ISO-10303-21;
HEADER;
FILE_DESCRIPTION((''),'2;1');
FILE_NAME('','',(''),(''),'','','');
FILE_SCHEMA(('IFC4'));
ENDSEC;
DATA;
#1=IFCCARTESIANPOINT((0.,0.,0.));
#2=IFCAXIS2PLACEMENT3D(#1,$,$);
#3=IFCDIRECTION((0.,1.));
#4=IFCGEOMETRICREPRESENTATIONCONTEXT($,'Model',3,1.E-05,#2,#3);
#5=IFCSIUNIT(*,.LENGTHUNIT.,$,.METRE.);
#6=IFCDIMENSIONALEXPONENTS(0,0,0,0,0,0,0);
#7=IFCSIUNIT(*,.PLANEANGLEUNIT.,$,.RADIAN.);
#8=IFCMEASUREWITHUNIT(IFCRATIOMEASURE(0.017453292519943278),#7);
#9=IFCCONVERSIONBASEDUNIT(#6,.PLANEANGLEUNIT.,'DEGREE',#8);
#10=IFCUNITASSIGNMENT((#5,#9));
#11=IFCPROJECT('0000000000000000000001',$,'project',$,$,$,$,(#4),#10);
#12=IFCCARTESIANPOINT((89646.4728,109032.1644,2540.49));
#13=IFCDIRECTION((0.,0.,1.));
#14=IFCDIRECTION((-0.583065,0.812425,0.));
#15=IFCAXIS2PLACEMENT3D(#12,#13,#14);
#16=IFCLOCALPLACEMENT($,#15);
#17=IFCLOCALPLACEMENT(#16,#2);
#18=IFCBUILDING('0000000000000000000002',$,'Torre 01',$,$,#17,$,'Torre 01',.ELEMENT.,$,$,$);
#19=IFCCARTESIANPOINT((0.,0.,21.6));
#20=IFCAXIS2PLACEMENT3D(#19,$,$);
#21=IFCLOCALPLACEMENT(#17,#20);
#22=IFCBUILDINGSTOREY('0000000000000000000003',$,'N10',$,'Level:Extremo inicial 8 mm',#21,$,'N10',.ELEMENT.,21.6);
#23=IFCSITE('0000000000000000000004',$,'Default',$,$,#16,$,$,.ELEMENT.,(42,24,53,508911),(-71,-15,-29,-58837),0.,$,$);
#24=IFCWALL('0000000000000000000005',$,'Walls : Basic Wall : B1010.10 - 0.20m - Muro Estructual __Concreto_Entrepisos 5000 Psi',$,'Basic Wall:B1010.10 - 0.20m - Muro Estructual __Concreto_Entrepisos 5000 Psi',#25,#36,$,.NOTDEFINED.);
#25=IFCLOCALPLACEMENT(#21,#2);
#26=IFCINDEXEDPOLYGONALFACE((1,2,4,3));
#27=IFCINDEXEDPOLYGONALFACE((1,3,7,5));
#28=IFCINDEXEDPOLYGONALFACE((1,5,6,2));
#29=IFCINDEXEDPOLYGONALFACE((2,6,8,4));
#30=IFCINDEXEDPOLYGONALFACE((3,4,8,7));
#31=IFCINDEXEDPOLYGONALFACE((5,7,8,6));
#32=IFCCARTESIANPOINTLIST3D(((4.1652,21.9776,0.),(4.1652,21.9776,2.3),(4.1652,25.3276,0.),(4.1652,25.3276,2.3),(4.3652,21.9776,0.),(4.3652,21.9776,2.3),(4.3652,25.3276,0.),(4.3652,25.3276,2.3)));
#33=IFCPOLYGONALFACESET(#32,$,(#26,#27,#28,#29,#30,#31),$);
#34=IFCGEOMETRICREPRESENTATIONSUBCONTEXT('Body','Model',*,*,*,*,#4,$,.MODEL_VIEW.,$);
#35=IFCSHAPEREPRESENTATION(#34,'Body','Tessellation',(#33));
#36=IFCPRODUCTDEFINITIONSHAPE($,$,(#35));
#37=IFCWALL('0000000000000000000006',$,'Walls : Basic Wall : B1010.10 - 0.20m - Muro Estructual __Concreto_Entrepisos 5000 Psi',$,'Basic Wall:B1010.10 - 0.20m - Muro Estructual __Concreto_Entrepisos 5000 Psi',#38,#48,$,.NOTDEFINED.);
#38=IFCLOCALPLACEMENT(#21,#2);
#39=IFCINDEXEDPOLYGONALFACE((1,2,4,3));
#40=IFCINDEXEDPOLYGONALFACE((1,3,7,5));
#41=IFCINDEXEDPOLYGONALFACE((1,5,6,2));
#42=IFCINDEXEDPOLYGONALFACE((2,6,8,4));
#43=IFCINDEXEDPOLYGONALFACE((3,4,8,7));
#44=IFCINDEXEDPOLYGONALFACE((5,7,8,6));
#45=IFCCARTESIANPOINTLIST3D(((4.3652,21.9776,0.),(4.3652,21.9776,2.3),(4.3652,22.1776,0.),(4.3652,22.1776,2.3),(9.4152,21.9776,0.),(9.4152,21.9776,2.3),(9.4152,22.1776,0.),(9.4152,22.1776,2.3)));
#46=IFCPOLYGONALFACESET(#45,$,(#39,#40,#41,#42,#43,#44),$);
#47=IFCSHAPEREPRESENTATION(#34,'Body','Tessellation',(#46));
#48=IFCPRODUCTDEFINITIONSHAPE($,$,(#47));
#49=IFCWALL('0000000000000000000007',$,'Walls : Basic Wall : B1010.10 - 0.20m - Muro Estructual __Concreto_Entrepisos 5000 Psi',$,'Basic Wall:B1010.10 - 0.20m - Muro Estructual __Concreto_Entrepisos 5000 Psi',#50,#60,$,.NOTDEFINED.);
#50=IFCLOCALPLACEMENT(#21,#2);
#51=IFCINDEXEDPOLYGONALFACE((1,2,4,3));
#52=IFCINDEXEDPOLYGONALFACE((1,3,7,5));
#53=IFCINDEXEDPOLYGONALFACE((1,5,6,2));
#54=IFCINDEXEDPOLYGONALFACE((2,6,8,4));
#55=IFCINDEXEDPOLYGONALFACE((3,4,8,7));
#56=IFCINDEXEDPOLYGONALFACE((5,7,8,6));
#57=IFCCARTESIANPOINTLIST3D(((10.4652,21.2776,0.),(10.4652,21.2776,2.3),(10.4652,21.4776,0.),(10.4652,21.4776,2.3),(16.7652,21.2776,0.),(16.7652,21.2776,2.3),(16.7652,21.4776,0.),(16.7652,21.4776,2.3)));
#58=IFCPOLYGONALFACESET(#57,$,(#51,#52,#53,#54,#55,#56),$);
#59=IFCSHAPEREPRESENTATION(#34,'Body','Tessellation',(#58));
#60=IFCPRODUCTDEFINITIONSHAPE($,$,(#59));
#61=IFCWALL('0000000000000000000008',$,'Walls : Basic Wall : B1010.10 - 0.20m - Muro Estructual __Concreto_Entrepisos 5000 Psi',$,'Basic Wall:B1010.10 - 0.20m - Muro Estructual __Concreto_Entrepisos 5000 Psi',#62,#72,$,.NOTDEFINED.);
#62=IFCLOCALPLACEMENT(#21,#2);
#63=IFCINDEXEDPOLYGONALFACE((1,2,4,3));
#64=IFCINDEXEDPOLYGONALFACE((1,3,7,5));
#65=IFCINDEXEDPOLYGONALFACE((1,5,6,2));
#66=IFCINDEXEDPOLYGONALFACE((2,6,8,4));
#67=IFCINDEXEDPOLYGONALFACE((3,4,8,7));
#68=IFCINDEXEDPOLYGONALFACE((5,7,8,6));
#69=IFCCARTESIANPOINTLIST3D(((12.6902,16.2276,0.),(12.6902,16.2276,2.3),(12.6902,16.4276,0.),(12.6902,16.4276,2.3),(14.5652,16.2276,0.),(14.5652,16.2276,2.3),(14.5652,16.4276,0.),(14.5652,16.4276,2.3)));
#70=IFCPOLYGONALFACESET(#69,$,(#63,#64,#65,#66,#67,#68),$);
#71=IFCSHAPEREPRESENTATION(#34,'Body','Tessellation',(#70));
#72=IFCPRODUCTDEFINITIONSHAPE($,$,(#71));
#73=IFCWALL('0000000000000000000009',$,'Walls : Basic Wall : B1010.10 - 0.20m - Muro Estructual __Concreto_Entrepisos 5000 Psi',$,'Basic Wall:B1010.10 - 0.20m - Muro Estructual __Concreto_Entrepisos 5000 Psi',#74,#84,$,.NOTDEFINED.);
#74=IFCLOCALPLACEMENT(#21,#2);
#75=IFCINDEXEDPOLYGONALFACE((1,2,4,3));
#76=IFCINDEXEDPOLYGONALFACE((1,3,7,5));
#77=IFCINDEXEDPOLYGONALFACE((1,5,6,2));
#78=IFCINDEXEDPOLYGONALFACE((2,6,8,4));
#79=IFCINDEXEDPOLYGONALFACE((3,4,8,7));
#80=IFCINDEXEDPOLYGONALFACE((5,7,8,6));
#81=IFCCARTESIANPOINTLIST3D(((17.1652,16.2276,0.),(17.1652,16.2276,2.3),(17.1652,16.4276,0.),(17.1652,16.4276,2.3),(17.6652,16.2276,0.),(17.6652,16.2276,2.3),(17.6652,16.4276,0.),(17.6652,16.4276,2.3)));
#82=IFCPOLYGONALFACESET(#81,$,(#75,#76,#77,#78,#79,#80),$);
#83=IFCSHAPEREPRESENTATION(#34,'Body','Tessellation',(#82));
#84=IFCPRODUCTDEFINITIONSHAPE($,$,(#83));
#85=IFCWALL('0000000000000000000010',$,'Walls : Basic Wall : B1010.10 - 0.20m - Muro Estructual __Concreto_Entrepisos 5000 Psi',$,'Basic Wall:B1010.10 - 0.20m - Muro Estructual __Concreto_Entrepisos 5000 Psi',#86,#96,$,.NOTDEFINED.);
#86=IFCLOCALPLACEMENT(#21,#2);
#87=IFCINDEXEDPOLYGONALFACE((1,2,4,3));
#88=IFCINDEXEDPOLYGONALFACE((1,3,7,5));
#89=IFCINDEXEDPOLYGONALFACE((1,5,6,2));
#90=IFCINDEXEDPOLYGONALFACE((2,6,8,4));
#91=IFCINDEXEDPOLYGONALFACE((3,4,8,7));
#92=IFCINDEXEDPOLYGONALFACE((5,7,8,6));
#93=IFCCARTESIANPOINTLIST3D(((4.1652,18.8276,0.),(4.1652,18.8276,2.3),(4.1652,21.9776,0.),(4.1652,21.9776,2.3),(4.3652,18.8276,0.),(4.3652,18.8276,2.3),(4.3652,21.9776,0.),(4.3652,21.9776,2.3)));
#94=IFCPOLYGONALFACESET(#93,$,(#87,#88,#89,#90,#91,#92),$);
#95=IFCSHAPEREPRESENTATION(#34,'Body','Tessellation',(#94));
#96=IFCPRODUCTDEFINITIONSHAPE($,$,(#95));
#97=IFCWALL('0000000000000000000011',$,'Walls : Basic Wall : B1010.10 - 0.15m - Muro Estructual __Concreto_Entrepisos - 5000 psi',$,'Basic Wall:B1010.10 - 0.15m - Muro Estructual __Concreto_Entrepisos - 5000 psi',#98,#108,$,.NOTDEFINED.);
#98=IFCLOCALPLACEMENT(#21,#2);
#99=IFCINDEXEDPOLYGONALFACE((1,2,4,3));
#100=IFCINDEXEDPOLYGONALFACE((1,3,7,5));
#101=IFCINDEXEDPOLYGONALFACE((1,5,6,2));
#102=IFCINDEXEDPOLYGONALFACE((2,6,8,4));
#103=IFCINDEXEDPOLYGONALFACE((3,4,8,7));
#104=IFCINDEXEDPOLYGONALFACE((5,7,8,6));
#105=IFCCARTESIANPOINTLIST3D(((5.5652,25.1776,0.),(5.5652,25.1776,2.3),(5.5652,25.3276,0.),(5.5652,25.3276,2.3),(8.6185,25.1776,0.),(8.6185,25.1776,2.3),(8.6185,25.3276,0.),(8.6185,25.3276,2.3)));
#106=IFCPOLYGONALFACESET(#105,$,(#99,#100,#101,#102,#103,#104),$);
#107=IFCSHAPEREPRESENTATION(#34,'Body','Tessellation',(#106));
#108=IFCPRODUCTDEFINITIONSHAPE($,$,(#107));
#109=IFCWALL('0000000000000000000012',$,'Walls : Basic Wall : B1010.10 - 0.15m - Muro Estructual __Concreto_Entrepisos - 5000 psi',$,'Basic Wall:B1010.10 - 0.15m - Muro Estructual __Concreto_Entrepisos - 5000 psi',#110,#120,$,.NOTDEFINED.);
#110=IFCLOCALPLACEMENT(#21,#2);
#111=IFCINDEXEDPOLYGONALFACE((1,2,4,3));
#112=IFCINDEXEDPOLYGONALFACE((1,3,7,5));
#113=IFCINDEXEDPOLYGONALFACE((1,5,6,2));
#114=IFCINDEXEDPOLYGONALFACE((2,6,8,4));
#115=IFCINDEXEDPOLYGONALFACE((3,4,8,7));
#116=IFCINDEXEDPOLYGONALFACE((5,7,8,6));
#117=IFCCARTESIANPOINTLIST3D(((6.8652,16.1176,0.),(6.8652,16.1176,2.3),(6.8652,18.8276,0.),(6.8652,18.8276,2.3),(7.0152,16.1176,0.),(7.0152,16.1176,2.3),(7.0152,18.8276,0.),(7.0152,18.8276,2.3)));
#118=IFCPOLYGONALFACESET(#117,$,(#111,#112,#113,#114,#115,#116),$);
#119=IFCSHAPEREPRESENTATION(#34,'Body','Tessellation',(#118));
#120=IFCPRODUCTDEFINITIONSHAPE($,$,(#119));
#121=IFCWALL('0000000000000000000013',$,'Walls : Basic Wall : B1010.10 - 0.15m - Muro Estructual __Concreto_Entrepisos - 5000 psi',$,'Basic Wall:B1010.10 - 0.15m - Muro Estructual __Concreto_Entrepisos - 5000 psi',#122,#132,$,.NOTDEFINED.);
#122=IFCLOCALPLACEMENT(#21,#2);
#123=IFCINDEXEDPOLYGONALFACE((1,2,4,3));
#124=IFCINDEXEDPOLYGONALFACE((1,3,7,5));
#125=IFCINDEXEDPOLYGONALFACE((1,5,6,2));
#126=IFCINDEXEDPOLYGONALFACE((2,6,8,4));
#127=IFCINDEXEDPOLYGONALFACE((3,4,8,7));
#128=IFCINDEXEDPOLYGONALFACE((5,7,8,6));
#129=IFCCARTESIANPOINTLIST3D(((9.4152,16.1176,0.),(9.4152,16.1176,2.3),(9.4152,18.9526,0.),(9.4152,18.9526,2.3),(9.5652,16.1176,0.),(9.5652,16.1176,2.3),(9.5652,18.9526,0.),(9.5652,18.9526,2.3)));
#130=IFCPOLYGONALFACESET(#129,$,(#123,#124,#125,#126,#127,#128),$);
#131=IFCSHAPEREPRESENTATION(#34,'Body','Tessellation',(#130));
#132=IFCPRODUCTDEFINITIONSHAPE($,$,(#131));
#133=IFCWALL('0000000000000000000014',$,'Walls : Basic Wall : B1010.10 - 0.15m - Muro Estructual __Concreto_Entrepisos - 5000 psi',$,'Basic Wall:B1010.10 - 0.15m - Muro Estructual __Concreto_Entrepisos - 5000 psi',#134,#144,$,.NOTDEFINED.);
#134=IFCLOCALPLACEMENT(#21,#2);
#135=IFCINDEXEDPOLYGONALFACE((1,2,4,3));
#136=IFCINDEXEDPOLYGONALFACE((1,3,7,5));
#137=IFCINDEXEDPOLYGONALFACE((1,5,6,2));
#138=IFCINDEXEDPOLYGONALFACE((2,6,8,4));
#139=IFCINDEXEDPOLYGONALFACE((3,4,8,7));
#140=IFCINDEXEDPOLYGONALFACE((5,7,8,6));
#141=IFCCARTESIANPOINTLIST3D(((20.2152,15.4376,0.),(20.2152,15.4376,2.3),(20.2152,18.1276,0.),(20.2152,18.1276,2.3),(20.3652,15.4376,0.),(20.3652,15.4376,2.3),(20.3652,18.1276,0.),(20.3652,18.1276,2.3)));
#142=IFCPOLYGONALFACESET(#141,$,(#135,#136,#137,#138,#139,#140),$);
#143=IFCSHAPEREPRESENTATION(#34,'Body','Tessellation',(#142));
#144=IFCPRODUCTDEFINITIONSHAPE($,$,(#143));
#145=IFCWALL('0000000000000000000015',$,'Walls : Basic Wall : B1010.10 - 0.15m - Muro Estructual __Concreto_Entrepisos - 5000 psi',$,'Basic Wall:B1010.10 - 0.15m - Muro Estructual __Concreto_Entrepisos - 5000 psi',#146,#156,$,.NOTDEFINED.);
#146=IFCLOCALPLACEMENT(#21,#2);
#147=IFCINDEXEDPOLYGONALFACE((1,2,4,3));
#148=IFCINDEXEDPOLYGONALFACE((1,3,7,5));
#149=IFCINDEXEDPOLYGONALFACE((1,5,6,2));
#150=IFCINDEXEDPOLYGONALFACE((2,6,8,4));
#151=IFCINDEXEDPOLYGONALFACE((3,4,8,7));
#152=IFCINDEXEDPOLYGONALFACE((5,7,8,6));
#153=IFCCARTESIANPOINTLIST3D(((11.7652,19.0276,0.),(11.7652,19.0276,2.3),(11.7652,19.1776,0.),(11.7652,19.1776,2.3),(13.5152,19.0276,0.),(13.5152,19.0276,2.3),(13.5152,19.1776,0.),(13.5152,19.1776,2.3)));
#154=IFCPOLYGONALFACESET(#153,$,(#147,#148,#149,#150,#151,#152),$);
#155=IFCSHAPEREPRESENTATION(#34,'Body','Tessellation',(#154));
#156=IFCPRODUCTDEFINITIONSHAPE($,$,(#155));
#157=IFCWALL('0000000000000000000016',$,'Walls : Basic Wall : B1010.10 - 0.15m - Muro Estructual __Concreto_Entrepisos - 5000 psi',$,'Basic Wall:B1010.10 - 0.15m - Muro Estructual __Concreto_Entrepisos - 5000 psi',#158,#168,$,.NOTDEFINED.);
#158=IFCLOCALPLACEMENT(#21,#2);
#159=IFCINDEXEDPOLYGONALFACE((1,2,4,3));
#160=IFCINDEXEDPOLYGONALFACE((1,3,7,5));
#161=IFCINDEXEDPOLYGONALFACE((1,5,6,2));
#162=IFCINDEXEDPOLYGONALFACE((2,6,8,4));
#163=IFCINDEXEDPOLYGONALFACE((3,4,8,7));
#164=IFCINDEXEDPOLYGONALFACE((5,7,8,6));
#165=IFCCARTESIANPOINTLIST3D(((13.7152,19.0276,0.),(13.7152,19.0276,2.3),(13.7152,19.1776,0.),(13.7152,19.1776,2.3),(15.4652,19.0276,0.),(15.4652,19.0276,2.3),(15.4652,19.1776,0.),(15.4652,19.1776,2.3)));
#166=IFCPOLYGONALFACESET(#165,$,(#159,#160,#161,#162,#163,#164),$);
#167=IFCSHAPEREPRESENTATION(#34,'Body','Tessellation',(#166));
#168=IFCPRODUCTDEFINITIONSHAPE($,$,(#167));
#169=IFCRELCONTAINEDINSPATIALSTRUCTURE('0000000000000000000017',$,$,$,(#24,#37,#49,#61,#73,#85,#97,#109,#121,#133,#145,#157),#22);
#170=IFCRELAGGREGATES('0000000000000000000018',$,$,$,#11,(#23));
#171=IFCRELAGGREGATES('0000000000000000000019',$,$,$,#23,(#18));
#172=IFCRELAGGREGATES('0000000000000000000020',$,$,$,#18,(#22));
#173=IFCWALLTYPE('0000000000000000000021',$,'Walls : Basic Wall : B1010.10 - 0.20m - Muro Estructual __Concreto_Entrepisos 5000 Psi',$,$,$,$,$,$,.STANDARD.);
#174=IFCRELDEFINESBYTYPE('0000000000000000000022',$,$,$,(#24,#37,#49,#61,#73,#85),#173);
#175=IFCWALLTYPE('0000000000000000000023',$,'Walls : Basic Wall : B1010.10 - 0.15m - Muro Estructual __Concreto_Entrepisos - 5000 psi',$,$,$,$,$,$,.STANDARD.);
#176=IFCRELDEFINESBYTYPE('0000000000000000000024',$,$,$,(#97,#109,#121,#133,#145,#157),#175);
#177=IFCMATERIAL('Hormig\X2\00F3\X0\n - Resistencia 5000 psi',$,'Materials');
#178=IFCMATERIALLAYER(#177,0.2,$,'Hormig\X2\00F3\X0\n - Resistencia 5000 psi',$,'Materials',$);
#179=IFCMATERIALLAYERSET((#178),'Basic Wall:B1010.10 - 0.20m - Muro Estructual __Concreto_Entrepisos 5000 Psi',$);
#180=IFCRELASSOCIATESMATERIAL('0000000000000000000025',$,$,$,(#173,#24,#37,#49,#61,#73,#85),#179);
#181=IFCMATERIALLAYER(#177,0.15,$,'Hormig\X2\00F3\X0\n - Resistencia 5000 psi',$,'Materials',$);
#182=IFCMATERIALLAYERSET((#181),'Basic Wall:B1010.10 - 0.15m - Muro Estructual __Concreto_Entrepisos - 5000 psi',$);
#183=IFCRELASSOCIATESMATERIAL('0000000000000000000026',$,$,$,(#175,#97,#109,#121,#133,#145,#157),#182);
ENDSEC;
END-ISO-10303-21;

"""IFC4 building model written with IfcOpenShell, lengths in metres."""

from ifc_helpers import new_model, entity, si_unit, converted_unit, direction, frame, frame_2d, origin, place, context, subcontext, project, spatial, rectangle, extrude, material, layer, layer_set, layer_usage, type_object, element, save


model = new_model("IFC4")

# Units and contexts
model_context = context("Model", 3, precision=1e-05, world=origin(), true_north=direction((0.0, 1.0)))
body_context = subcontext(model_context, "Body", "Model", "MODEL_VIEW")
ifc_project = project(units=[si_unit("LENGTHUNIT", "METRE"), converted_unit("PLANEANGLEUNIT", "DEGREE", entity("IfcRatioMeasure", 0.017453292519943278), si_unit("PLANEANGLEUNIT", "RADIAN"), dimensions=[0, 0, 0, 0, 0, 0, 0])], contexts=[model_context])

# Site, building, storey
site_placement = place(None, frame((89646.4728, 109032.1644, 2540.49), z_axis=(0.0, 0.0, 1.0), x_axis=(-0.583065, 0.812425, 0.0)))
site = spatial("IfcSite", under=ifc_project, at=site_placement, Name="Default", CompositionType="ELEMENT", RefLatitude=(42, 24, 53, 508911), RefLongitude=(-71, -15, -29, -58837), RefElevation=0.0)
building_placement = place(site_placement, origin())
building = spatial("IfcBuilding", under=site, at=building_placement, Name="Torre 01", LongName="Torre 01", CompositionType="ELEMENT")
storey_placement = place(building_placement, frame((0.0, 0.0, 21.6)))
storey = spatial("IfcBuildingStorey", under=building, at=storey_placement, Name="N10", ObjectType="Level:Extremo inicial 8 mm", LongName="N10", CompositionType="ELEMENT", Elevation=21.6)

# Walls
ifc_material = material(Name="Hormigón - Resistencia 5000 psi", Category="Materials")
ifc_layer_1 = layer(ifc_material, 0.2, Name="Hormigón - Resistencia 5000 psi", Category="Materials")
ifc_layer_set_1 = layer_set([ifc_layer_1], Name="Basic Wall:B1010.10 - 0.20m - Muro Estructual __Concreto_Entrepisos 5000 Psi")
ifc_layer_usage_1 = layer_usage(ifc_layer_set_1, "AXIS2", "NEGATIVE", 0.1)
wall_type_1 = type_object("IfcWallType", Name="Walls : Basic Wall : B1010.10 - 0.20m - Muro Estructual __Concreto_Entrepisos 5000 Psi", PredefinedType="STANDARD", material=ifc_layer_set_1)
wall_1_placement = place(storey_placement, frame((4.2652, 25.3276, 0.0), z_axis=(0.0, 0.0, 1.0), x_axis=(0.0, -1.0, 0.0)))
element("IfcWall", 1, at=wall_1_placement, inside=storey, type_object=wall_type_1, material=ifc_layer_usage_1, Name="Walls : Basic Wall : B1010.10 - 0.20m - Muro Estructual __Concreto_Entrepisos 5000 Psi", ObjectType="Basic Wall:B1010.10 - 0.20m - Muro Estructual __Concreto_Entrepisos 5000 Psi", PredefinedType="NOTDEFINED", context=body_context, shape_type="SweptSolid", body=[
    extrude(rectangle(XDim=3.35, YDim=0.2, at=frame_2d((1.675, 0.0), x_axis=(-1.0, 0.0))), origin(), (0.0, 0.0, 1.0), 2.3),
])
ifc_layer_usage_2 = layer_usage(ifc_layer_set_1, "AXIS2", "NEGATIVE", 0.1)
wall_2_placement = place(storey_placement, frame((4.3652, 22.0776, 0.0)))
element("IfcWall", 2, at=wall_2_placement, inside=storey, type_object=wall_type_1, material=ifc_layer_usage_2, Name="Walls : Basic Wall : B1010.10 - 0.20m - Muro Estructual __Concreto_Entrepisos 5000 Psi", ObjectType="Basic Wall:B1010.10 - 0.20m - Muro Estructual __Concreto_Entrepisos 5000 Psi", PredefinedType="NOTDEFINED", context=body_context, shape_type="SweptSolid", body=[
    extrude(rectangle(XDim=5.05, YDim=0.2, at=frame_2d((2.525, 0.0), x_axis=(-1.0, 0.0))), origin(), (0.0, 0.0, 1.0), 2.3),
])
ifc_layer_usage_3 = layer_usage(ifc_layer_set_1, "AXIS2", "NEGATIVE", 0.1)
wall_3_placement = place(storey_placement, frame((10.4652, 21.3776, 0.0)))
element("IfcWall", 3, at=wall_3_placement, inside=storey, type_object=wall_type_1, material=ifc_layer_usage_3, Name="Walls : Basic Wall : B1010.10 - 0.20m - Muro Estructual __Concreto_Entrepisos 5000 Psi", ObjectType="Basic Wall:B1010.10 - 0.20m - Muro Estructual __Concreto_Entrepisos 5000 Psi", PredefinedType="NOTDEFINED", context=body_context, shape_type="SweptSolid", body=[
    extrude(rectangle(XDim=6.3, YDim=0.2, at=frame_2d((3.15, 0.0), x_axis=(-1.0, 0.0))), origin(), (0.0, 0.0, 1.0), 2.3),
])
ifc_layer_usage_4 = layer_usage(ifc_layer_set_1, "AXIS2", "NEGATIVE", 0.1)
wall_4_placement = place(storey_placement, frame((12.6902, 16.3276, 0.0)))
element("IfcWall", 4, at=wall_4_placement, inside=storey, type_object=wall_type_1, material=ifc_layer_usage_4, Name="Walls : Basic Wall : B1010.10 - 0.20m - Muro Estructual __Concreto_Entrepisos 5000 Psi", ObjectType="Basic Wall:B1010.10 - 0.20m - Muro Estructual __Concreto_Entrepisos 5000 Psi", PredefinedType="NOTDEFINED", context=body_context, shape_type="SweptSolid", body=[
    extrude(rectangle(XDim=1.875, YDim=0.2, at=frame_2d((0.9375, 0.0), x_axis=(-1.0, 0.0))), origin(), (0.0, 0.0, 1.0), 2.3),
])
ifc_layer_usage_5 = layer_usage(ifc_layer_set_1, "AXIS2", "NEGATIVE", 0.1)
wall_5_placement = place(storey_placement, frame((17.6652, 16.3276, 0.0), z_axis=(0.0, 0.0, 1.0), x_axis=(-1.0, 0.0, 0.0)))
element("IfcWall", 5, at=wall_5_placement, inside=storey, type_object=wall_type_1, material=ifc_layer_usage_5, Name="Walls : Basic Wall : B1010.10 - 0.20m - Muro Estructual __Concreto_Entrepisos 5000 Psi", ObjectType="Basic Wall:B1010.10 - 0.20m - Muro Estructual __Concreto_Entrepisos 5000 Psi", PredefinedType="NOTDEFINED", context=body_context, shape_type="SweptSolid", body=[
    extrude(rectangle(XDim=0.5, YDim=0.2, at=frame_2d((0.25, 0.0), x_axis=(-1.0, 0.0))), origin(), (0.0, 0.0, 1.0), 2.3),
])
ifc_layer_usage_6 = layer_usage(ifc_layer_set_1, "AXIS2", "NEGATIVE", 0.1)
wall_6_placement = place(storey_placement, frame((4.2652, 21.9776, 0.0), z_axis=(0.0, 0.0, 1.0), x_axis=(0.0, -1.0, 0.0)))
element("IfcWall", 6, at=wall_6_placement, inside=storey, type_object=wall_type_1, material=ifc_layer_usage_6, Name="Walls : Basic Wall : B1010.10 - 0.20m - Muro Estructual __Concreto_Entrepisos 5000 Psi", ObjectType="Basic Wall:B1010.10 - 0.20m - Muro Estructual __Concreto_Entrepisos 5000 Psi", PredefinedType="NOTDEFINED", context=body_context, shape_type="SweptSolid", body=[
    extrude(rectangle(XDim=3.15, YDim=0.2, at=frame_2d((1.575, 0.0), x_axis=(-1.0, 0.0))), origin(), (0.0, 0.0, 1.0), 2.3),
])
ifc_layer_2 = layer(ifc_material, 0.15, Name="Hormigón - Resistencia 5000 psi", Category="Materials")
ifc_layer_set_2 = layer_set([ifc_layer_2], Name="Basic Wall:B1010.10 - 0.15m - Muro Estructual __Concreto_Entrepisos - 5000 psi")
ifc_layer_usage_7 = layer_usage(ifc_layer_set_2, "AXIS2", "NEGATIVE", 0.075)
wall_type_2 = type_object("IfcWallType", Name="Walls : Basic Wall : B1010.10 - 0.15m - Muro Estructual __Concreto_Entrepisos - 5000 psi", PredefinedType="STANDARD", material=ifc_layer_set_2)
wall_7_placement = place(storey_placement, frame((5.5652, 25.2526, 0.0)))
element("IfcWall", 7, at=wall_7_placement, inside=storey, type_object=wall_type_2, material=ifc_layer_usage_7, Name="Walls : Basic Wall : B1010.10 - 0.15m - Muro Estructual __Concreto_Entrepisos - 5000 psi", ObjectType="Basic Wall:B1010.10 - 0.15m - Muro Estructual __Concreto_Entrepisos - 5000 psi", PredefinedType="NOTDEFINED", context=body_context, shape_type="SweptSolid", body=[
    extrude(rectangle(XDim=3.0533, YDim=0.15, at=frame_2d((1.5267, 0.0), x_axis=(-1.0, 0.0))), origin(), (0.0, 0.0, 1.0), 2.3),
])
ifc_layer_usage_8 = layer_usage(ifc_layer_set_2, "AXIS2", "NEGATIVE", 0.075)
wall_8_placement = place(storey_placement, frame((6.9402, 18.8276, 0.0), z_axis=(0.0, 0.0, 1.0), x_axis=(0.0, -1.0, 0.0)))
element("IfcWall", 8, at=wall_8_placement, inside=storey, type_object=wall_type_2, material=ifc_layer_usage_8, Name="Walls : Basic Wall : B1010.10 - 0.15m - Muro Estructual __Concreto_Entrepisos - 5000 psi", ObjectType="Basic Wall:B1010.10 - 0.15m - Muro Estructual __Concreto_Entrepisos - 5000 psi", PredefinedType="NOTDEFINED", context=body_context, shape_type="SweptSolid", body=[
    extrude(rectangle(XDim=2.71, YDim=0.15, at=frame_2d((1.355, 0.0), x_axis=(-1.0, 0.0))), origin(), (0.0, 0.0, 1.0), 2.3),
])
ifc_layer_usage_9 = layer_usage(ifc_layer_set_2, "AXIS2", "NEGATIVE", 0.075)
wall_9_placement = place(storey_placement, frame((9.4902, 18.9526, 0.0), z_axis=(0.0, 0.0, 1.0), x_axis=(0.0, -1.0, 0.0)))
element("IfcWall", 9, at=wall_9_placement, inside=storey, type_object=wall_type_2, material=ifc_layer_usage_9, Name="Walls : Basic Wall : B1010.10 - 0.15m - Muro Estructual __Concreto_Entrepisos - 5000 psi", ObjectType="Basic Wall:B1010.10 - 0.15m - Muro Estructual __Concreto_Entrepisos - 5000 psi", PredefinedType="NOTDEFINED", context=body_context, shape_type="SweptSolid", body=[
    extrude(rectangle(XDim=2.835, YDim=0.15, at=frame_2d((1.4175, 0.0), x_axis=(-1.0, 0.0))), origin(), (0.0, 0.0, 1.0), 2.3),
])
ifc_layer_usage_10 = layer_usage(ifc_layer_set_2, "AXIS2", "NEGATIVE", 0.075)
wall_10_placement = place(storey_placement, frame((20.2902, 15.4376, 0.0), z_axis=(0.0, 0.0, 1.0), x_axis=(0.0, 1.0, 0.0)))
element("IfcWall", 10, at=wall_10_placement, inside=storey, type_object=wall_type_2, material=ifc_layer_usage_10, Name="Walls : Basic Wall : B1010.10 - 0.15m - Muro Estructual __Concreto_Entrepisos - 5000 psi", ObjectType="Basic Wall:B1010.10 - 0.15m - Muro Estructual __Concreto_Entrepisos - 5000 psi", PredefinedType="NOTDEFINED", context=body_context, shape_type="SweptSolid", body=[
    extrude(rectangle(XDim=2.69, YDim=0.15, at=frame_2d((1.345, 0.0), x_axis=(-1.0, 0.0))), origin(), (0.0, 0.0, 1.0), 2.3),
])
ifc_layer_usage_11 = layer_usage(ifc_layer_set_2, "AXIS2", "NEGATIVE", 0.075)
wall_11_placement = place(storey_placement, frame((11.7652, 19.1026, 0.0)))
element("IfcWall", 11, at=wall_11_placement, inside=storey, type_object=wall_type_2, material=ifc_layer_usage_11, Name="Walls : Basic Wall : B1010.10 - 0.15m - Muro Estructual __Concreto_Entrepisos - 5000 psi", ObjectType="Basic Wall:B1010.10 - 0.15m - Muro Estructual __Concreto_Entrepisos - 5000 psi", PredefinedType="NOTDEFINED", context=body_context, shape_type="SweptSolid", body=[
    extrude(rectangle(XDim=1.75, YDim=0.15, at=frame_2d((0.875, 0.0), x_axis=(-1.0, 0.0))), origin(), (0.0, 0.0, 1.0), 2.3),
])
ifc_layer_usage_12 = layer_usage(ifc_layer_set_2, "AXIS2", "NEGATIVE", 0.075)
wall_12_placement = place(storey_placement, frame((13.7152, 19.1026, 0.0)))
element("IfcWall", 12, at=wall_12_placement, inside=storey, type_object=wall_type_2, material=ifc_layer_usage_12, Name="Walls : Basic Wall : B1010.10 - 0.15m - Muro Estructual __Concreto_Entrepisos - 5000 psi", ObjectType="Basic Wall:B1010.10 - 0.15m - Muro Estructual __Concreto_Entrepisos - 5000 psi", PredefinedType="NOTDEFINED", context=body_context, shape_type="SweptSolid", body=[
    extrude(rectangle(XDim=1.75, YDim=0.15, at=frame_2d((0.875, 0.0), x_axis=(-1.0, 0.0))), origin(), (0.0, 0.0, 1.0), 2.3),
])

save(model, "model.ifc")
